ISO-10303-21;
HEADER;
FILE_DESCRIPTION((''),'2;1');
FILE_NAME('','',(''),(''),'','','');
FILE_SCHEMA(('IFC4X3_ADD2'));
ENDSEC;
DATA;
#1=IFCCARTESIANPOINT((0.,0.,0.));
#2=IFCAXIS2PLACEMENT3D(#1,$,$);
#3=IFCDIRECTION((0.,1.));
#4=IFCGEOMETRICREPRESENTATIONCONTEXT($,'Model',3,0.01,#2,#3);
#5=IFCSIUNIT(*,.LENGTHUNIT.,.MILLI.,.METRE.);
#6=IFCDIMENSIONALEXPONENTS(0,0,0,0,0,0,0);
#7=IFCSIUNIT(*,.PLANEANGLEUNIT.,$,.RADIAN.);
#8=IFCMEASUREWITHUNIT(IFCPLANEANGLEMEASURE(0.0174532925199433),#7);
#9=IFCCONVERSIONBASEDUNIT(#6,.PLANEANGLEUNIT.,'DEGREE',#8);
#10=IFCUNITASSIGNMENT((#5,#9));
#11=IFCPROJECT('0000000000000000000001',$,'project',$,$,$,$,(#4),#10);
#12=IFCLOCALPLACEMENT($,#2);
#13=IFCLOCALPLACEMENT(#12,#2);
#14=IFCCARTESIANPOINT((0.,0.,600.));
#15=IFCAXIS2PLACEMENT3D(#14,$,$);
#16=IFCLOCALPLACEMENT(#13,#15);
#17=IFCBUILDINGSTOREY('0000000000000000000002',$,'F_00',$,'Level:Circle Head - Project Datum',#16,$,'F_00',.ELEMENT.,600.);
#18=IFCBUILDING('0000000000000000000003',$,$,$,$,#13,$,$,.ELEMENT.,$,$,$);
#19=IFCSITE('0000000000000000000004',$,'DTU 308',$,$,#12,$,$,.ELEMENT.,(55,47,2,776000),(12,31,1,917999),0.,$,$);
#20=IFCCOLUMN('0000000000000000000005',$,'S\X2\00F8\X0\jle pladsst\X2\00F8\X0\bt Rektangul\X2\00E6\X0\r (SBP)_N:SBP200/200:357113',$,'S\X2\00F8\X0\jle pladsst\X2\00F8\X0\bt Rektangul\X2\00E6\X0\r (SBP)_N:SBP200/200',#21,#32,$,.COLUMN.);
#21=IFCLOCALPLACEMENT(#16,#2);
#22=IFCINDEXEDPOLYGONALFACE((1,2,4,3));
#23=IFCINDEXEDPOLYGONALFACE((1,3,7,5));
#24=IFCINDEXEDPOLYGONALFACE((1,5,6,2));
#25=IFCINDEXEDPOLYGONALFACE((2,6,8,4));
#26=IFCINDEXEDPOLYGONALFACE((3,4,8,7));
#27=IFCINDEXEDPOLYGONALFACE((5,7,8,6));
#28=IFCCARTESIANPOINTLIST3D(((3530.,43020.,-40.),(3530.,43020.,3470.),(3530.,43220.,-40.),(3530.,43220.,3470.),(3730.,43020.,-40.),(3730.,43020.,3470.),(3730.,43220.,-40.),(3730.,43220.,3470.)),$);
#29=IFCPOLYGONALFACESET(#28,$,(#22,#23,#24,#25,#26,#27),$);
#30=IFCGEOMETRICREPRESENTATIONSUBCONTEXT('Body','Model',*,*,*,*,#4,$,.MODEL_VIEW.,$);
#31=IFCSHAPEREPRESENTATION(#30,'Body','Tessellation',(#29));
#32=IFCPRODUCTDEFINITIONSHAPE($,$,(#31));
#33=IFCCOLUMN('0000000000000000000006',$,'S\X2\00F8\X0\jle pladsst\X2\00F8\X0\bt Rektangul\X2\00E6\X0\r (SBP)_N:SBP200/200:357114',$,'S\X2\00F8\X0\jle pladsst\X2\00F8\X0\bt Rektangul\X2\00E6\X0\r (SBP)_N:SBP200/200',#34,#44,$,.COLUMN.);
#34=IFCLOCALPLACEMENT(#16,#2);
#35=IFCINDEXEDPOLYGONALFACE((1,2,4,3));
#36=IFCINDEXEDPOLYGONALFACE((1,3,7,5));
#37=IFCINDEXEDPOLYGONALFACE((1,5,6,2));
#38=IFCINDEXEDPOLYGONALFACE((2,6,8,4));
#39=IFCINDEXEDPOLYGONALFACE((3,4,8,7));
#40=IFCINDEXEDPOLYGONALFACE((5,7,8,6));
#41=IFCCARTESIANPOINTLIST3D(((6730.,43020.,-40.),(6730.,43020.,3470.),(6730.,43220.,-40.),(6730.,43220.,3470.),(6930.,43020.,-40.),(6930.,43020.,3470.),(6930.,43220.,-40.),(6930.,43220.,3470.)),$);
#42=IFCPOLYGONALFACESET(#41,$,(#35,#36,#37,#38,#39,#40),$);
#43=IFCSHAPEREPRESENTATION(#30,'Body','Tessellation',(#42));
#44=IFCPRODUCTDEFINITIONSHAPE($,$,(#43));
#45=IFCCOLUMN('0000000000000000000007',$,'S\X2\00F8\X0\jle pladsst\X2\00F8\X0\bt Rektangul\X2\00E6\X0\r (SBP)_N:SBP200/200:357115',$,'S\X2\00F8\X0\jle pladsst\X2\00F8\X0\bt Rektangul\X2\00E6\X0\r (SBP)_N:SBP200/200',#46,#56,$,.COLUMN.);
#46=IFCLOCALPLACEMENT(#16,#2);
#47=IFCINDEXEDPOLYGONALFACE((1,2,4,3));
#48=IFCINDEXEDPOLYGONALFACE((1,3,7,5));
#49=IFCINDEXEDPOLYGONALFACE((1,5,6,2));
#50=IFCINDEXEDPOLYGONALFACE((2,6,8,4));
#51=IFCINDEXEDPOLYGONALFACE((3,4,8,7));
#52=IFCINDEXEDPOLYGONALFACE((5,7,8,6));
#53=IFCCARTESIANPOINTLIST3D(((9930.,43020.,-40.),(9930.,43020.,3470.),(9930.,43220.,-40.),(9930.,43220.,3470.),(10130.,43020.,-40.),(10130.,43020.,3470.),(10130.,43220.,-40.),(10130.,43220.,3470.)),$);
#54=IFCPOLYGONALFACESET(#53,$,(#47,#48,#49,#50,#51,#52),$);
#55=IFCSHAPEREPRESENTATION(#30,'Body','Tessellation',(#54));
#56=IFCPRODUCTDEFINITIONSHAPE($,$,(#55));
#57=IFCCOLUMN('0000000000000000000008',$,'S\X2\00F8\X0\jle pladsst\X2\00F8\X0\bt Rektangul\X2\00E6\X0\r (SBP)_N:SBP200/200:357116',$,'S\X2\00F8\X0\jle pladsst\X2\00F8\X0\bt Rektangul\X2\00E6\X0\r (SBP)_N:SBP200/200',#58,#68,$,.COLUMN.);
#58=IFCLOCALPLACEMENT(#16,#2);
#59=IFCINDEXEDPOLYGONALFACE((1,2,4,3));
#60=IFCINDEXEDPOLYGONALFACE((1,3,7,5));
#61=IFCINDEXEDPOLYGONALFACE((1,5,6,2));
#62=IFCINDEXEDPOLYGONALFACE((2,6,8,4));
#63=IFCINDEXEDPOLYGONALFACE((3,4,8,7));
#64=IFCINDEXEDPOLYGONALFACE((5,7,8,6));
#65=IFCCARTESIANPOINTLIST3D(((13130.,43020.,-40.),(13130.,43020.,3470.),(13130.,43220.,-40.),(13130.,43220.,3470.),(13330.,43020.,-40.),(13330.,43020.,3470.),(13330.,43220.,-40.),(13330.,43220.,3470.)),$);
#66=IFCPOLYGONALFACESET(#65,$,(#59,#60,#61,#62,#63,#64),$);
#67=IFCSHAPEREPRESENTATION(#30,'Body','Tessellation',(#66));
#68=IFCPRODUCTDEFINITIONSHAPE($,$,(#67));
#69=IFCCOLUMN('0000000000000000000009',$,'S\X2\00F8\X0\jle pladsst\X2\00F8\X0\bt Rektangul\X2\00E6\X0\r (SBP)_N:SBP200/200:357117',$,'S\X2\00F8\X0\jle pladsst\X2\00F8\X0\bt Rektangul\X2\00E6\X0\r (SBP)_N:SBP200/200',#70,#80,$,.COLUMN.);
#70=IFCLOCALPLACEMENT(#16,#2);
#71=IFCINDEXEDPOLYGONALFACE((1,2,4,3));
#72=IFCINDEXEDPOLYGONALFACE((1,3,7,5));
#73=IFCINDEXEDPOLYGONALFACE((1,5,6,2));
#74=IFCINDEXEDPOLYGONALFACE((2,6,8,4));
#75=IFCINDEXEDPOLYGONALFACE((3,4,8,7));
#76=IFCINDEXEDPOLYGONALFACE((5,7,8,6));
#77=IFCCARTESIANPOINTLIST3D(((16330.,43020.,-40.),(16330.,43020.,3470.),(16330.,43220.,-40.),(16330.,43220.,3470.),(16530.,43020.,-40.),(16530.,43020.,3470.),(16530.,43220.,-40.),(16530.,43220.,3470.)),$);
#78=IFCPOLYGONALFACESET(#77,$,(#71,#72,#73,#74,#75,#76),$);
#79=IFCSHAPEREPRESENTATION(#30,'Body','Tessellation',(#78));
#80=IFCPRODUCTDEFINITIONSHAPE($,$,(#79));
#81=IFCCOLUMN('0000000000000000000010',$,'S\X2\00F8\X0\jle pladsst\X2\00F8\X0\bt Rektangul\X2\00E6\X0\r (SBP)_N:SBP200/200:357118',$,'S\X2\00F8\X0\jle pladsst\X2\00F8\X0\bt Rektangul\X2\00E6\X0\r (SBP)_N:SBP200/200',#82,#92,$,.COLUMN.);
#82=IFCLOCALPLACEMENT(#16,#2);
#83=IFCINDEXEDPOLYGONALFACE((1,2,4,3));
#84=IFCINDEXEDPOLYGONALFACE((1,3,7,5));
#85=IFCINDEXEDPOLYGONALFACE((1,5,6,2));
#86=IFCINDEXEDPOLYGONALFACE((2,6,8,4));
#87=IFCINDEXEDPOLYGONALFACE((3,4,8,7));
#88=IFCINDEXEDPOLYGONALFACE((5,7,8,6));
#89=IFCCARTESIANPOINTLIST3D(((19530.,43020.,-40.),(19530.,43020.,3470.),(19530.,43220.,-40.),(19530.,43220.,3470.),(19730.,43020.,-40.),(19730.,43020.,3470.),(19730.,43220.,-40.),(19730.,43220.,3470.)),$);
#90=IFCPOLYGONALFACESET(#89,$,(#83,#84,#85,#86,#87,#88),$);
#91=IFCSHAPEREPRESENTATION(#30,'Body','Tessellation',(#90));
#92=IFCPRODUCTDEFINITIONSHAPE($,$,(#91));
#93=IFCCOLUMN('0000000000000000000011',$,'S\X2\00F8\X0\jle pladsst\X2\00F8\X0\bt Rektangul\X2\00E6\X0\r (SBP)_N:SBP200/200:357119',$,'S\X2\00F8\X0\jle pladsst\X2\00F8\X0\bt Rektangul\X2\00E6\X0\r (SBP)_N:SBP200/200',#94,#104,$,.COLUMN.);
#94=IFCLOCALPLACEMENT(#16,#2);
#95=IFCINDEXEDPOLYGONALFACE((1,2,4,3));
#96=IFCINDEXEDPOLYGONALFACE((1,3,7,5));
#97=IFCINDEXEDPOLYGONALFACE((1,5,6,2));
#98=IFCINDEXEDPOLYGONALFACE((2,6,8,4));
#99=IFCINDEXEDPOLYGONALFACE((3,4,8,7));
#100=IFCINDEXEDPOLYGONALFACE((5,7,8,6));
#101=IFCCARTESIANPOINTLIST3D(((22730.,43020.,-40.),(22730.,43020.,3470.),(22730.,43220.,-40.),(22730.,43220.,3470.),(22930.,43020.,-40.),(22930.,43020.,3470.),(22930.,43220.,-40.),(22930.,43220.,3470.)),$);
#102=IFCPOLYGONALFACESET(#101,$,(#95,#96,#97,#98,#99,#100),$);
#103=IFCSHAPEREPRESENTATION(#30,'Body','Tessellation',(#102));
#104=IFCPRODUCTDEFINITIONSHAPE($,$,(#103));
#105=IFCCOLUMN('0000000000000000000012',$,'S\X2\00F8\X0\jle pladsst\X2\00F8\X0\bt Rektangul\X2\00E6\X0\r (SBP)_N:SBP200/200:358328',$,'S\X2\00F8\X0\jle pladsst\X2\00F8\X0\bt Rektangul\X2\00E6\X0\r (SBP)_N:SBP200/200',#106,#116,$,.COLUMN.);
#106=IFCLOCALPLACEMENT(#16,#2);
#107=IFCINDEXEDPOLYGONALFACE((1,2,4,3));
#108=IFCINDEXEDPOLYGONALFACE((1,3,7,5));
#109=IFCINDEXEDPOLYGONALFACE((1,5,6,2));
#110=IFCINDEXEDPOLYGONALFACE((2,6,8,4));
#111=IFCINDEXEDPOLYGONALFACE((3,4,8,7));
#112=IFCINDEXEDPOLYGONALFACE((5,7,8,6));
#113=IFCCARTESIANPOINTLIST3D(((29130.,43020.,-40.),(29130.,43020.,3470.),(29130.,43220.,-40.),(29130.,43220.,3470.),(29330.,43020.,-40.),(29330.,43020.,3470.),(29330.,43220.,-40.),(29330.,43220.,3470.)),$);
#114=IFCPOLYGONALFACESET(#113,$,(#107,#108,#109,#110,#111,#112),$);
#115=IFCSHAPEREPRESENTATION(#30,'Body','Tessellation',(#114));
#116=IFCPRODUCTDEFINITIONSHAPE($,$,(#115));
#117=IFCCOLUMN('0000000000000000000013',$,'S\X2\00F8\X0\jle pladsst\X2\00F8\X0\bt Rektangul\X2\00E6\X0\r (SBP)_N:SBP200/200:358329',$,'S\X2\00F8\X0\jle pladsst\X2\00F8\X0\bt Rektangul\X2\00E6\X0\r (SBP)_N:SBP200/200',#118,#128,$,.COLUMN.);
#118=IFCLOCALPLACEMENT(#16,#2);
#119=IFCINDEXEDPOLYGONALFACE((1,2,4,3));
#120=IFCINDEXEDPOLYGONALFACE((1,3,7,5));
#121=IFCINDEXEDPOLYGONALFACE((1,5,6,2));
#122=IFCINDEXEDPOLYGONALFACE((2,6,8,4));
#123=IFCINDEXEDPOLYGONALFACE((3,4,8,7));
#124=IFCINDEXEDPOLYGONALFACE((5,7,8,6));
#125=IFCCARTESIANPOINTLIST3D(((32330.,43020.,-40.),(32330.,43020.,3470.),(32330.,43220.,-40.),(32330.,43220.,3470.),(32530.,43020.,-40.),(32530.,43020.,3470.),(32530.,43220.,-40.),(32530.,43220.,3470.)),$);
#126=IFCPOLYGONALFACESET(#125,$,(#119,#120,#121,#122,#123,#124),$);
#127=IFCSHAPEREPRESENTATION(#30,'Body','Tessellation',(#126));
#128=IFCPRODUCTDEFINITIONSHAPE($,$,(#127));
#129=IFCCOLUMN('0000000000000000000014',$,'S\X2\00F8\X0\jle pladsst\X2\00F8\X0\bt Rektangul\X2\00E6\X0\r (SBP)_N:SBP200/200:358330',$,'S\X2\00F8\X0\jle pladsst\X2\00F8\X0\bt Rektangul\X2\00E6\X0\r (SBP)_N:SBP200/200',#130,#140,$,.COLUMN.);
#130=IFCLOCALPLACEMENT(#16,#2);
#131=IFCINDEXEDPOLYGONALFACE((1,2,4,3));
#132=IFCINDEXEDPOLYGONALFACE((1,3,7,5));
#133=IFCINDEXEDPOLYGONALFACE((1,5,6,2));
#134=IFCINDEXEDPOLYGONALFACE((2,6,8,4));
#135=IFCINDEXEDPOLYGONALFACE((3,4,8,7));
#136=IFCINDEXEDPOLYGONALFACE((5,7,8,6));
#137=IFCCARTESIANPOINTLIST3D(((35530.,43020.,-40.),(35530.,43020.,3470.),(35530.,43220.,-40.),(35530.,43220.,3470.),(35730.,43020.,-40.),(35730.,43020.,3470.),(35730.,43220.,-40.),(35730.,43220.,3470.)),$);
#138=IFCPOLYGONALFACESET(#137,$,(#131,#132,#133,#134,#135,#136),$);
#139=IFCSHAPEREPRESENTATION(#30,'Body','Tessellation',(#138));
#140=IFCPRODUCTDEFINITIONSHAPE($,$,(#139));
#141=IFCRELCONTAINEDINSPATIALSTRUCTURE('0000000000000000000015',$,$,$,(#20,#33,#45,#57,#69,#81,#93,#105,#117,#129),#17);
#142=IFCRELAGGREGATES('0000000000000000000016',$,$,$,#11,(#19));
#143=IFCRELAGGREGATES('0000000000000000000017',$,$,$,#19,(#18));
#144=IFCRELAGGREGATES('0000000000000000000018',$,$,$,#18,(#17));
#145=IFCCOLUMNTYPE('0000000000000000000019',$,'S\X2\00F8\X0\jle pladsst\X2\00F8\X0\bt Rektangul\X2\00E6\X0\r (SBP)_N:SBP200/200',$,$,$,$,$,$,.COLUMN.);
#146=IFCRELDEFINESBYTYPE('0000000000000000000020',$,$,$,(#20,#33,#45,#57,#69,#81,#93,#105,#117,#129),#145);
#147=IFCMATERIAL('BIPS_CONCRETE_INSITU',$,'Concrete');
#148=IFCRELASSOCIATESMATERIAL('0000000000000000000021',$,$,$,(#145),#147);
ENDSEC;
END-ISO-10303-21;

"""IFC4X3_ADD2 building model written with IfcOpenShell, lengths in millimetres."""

from ifc_helpers import new_model, entity, si_unit, converted_unit, direction, frame, frame_2d, origin, place, context, subcontext, project, spatial, rectangle, extrude, source, transform, mapped, material, material_profile, profile_set, type_object, element, save


model = new_model("IFC4X3_ADD2")

# Units and contexts
model_context = context("Model", 3, precision=0.01, world=origin(), true_north=direction((0.0, 1.0)))
body_context = subcontext(model_context, "Body", "Model", "MODEL_VIEW")
ifc_project = project(units=[si_unit("LENGTHUNIT", "METRE", prefix="MILLI"), converted_unit("PLANEANGLEUNIT", "DEGREE", entity("IfcPlaneAngleMeasure", 0.0174532925199433), si_unit("PLANEANGLEUNIT", "RADIAN"), dimensions=[0, 0, 0, 0, 0, 0, 0])], contexts=[model_context])

# Site, building, storey
site_placement = place(None, origin())
site = spatial("IfcSite", under=ifc_project, at=site_placement, Name="DTU 308", CompositionType="ELEMENT", RefLatitude=(55, 47, 2, 776000), RefLongitude=(12, 31, 1, 917999), RefElevation=0.0)
building_placement = place(site_placement, origin())
building = spatial("IfcBuilding", under=site, at=building_placement, CompositionType="ELEMENT")
storey_placement = place(building_placement, frame((0.0, 0.0, 600.0)))
storey = spatial("IfcBuildingStorey", under=building, at=storey_placement, Name="F_00", ObjectType="Level:Circle Head - Project Datum", LongName="F_00", CompositionType="ELEMENT", Elevation=600.0)

# Columns
ifc_material_1 = material(Name="BIPS_CONCRETE_INSITU", Category="Concrete")
ifc_material_profile_1 = material_profile(ifc_material_1, rectangle(XDim=200.0, YDim=200.0, at=frame_2d((0.0, 0.0), x_axis=(1.0, 0.0))), Name="SBP200/200")
ifc_profile_set_1 = profile_set([ifc_material_profile_1], Name="SBP200/200")
column_type_1 = type_object("IfcColumnType", Name="Søjle pladsstøbt Rektangulær (SBP)_N:SBP200/200", PredefinedType="COLUMN", material=ifc_profile_set_1)
shared_shape_1 = source(origin(), body_context, "Body", "SweptSolid", [
    extrude(rectangle(XDim=200.0, YDim=200.0, at=frame_2d((0.0, 0.0), x_axis=(1.0, 0.0))), frame((3630.0, 43120.0, 560.0), z_axis=(0.0, 0.0, 1.0), x_axis=(0.0, 1.0, 0.0)), (0.0, 0.0, 1.0), 3510.0),
])
column_1_placement = place(storey_placement, frame((0.0, 0.0, -600.0)))
element("IfcColumn", 1, at=column_1_placement, inside=storey, type_object=column_type_1, Name="Søjle pladsstøbt Rektangulær (SBP)_N:SBP200/200:357113", ObjectType="Søjle pladsstøbt Rektangulær (SBP)_N:SBP200/200", PredefinedType="COLUMN", context=body_context, shape_type="MappedRepresentation", body=[
    mapped(shared_shape_1, transform((0.0, 0.0, 0.0), scale=1.0)),
])
shared_shape_2 = source(origin(), body_context, "Body", "SweptSolid", [
    extrude(rectangle(XDim=200.0, YDim=200.0, at=frame_2d((0.0, 0.0), x_axis=(1.0, 0.0))), frame((6830.0, 43120.0, 560.0), z_axis=(0.0, 0.0, 1.0), x_axis=(0.0, 1.0, 0.0)), (0.0, 0.0, 1.0), 3510.0),
])
column_2_placement = place(storey_placement, frame((0.0, 0.0, -600.0)))
element("IfcColumn", 2, at=column_2_placement, inside=storey, type_object=column_type_1, Name="Søjle pladsstøbt Rektangulær (SBP)_N:SBP200/200:357114", ObjectType="Søjle pladsstøbt Rektangulær (SBP)_N:SBP200/200", PredefinedType="COLUMN", context=body_context, shape_type="MappedRepresentation", body=[
    mapped(shared_shape_2, transform((0.0, 0.0, 0.0), scale=1.0)),
])
shared_shape_3 = source(origin(), body_context, "Body", "SweptSolid", [
    extrude(rectangle(XDim=200.0, YDim=200.0, at=frame_2d((0.0, 0.0), x_axis=(1.0, 0.0))), frame((10030.0, 43120.0, 560.0), z_axis=(0.0, 0.0, 1.0), x_axis=(0.0, 1.0, 0.0)), (0.0, 0.0, 1.0), 3510.0),
])
column_3_placement = place(storey_placement, frame((0.0, 0.0, -600.0)))
element("IfcColumn", 3, at=column_3_placement, inside=storey, type_object=column_type_1, Name="Søjle pladsstøbt Rektangulær (SBP)_N:SBP200/200:357115", ObjectType="Søjle pladsstøbt Rektangulær (SBP)_N:SBP200/200", PredefinedType="COLUMN", context=body_context, shape_type="MappedRepresentation", body=[
    mapped(shared_shape_3, transform((0.0, 0.0, 0.0), scale=1.0)),
])
shared_shape_4 = source(origin(), body_context, "Body", "SweptSolid", [
    extrude(rectangle(XDim=200.0, YDim=200.0, at=frame_2d((0.0, 0.0), x_axis=(1.0, 0.0))), frame((13230.0, 43120.0, 560.0), z_axis=(0.0, 0.0, 1.0), x_axis=(0.0, 1.0, 0.0)), (0.0, 0.0, 1.0), 3510.0),
])
column_4_placement = place(storey_placement, frame((0.0, 0.0, -600.0)))
element("IfcColumn", 4, at=column_4_placement, inside=storey, type_object=column_type_1, Name="Søjle pladsstøbt Rektangulær (SBP)_N:SBP200/200:357116", ObjectType="Søjle pladsstøbt Rektangulær (SBP)_N:SBP200/200", PredefinedType="COLUMN", context=body_context, shape_type="MappedRepresentation", body=[
    mapped(shared_shape_4, transform((0.0, 0.0, 0.0), scale=1.0)),
])
shared_shape_5 = source(origin(), body_context, "Body", "SweptSolid", [
    extrude(rectangle(XDim=200.0, YDim=200.0, at=frame_2d((0.0, 0.0), x_axis=(1.0, 0.0))), frame((16430.0, 43120.0, 560.0), z_axis=(0.0, 0.0, 1.0), x_axis=(0.0, 1.0, 0.0)), (0.0, 0.0, 1.0), 3510.0),
])
column_5_placement = place(storey_placement, frame((0.0, 0.0, -600.0)))
element("IfcColumn", 5, at=column_5_placement, inside=storey, type_object=column_type_1, Name="Søjle pladsstøbt Rektangulær (SBP)_N:SBP200/200:357117", ObjectType="Søjle pladsstøbt Rektangulær (SBP)_N:SBP200/200", PredefinedType="COLUMN", context=body_context, shape_type="MappedRepresentation", body=[
    mapped(shared_shape_5, transform((0.0, 0.0, 0.0), scale=1.0)),
])
shared_shape_6 = source(origin(), body_context, "Body", "SweptSolid", [
    extrude(rectangle(XDim=200.0, YDim=200.0, at=frame_2d((0.0, 0.0), x_axis=(1.0, 0.0))), frame((19630.0, 43120.0, 560.0), z_axis=(0.0, 0.0, 1.0), x_axis=(0.0, 1.0, 0.0)), (0.0, 0.0, 1.0), 3510.0),
])
column_6_placement = place(storey_placement, frame((0.0, 0.0, -600.0)))
element("IfcColumn", 6, at=column_6_placement, inside=storey, type_object=column_type_1, Name="Søjle pladsstøbt Rektangulær (SBP)_N:SBP200/200:357118", ObjectType="Søjle pladsstøbt Rektangulær (SBP)_N:SBP200/200", PredefinedType="COLUMN", context=body_context, shape_type="MappedRepresentation", body=[
    mapped(shared_shape_6, transform((0.0, 0.0, 0.0), scale=1.0)),
])
shared_shape_7 = source(origin(), body_context, "Body", "SweptSolid", [
    extrude(rectangle(XDim=200.0, YDim=200.0, at=frame_2d((0.0, 0.0), x_axis=(1.0, 0.0))), frame((22830.0, 43120.0, 560.0), z_axis=(0.0, 0.0, 1.0), x_axis=(0.0, 1.0, 0.0)), (0.0, 0.0, 1.0), 3510.0),
])
column_7_placement = place(storey_placement, frame((0.0, 0.0, -600.0)))
element("IfcColumn", 7, at=column_7_placement, inside=storey, type_object=column_type_1, Name="Søjle pladsstøbt Rektangulær (SBP)_N:SBP200/200:357119", ObjectType="Søjle pladsstøbt Rektangulær (SBP)_N:SBP200/200", PredefinedType="COLUMN", context=body_context, shape_type="MappedRepresentation", body=[
    mapped(shared_shape_7, transform((0.0, 0.0, 0.0), scale=1.0)),
])
shared_shape_8 = source(origin(), body_context, "Body", "SweptSolid", [
    extrude(rectangle(XDim=200.0, YDim=200.0, at=frame_2d((0.0, 0.0), x_axis=(1.0, 0.0))), frame((29230.0, 43120.0, 560.0), z_axis=(0.0, 0.0, 1.0), x_axis=(0.0, 1.0, 0.0)), (0.0, 0.0, 1.0), 3510.0),
])
column_8_placement = place(storey_placement, frame((0.0, 0.0, -600.0)))
element("IfcColumn", 8, at=column_8_placement, inside=storey, type_object=column_type_1, Name="Søjle pladsstøbt Rektangulær (SBP)_N:SBP200/200:358328", ObjectType="Søjle pladsstøbt Rektangulær (SBP)_N:SBP200/200", PredefinedType="COLUMN", context=body_context, shape_type="MappedRepresentation", body=[
    mapped(shared_shape_8, transform((0.0, 0.0, 0.0), scale=1.0)),
])
shared_shape_9 = source(origin(), body_context, "Body", "SweptSolid", [
    extrude(rectangle(XDim=200.0, YDim=200.0, at=frame_2d((0.0, 0.0), x_axis=(1.0, 0.0))), frame((32430.0, 43120.0, 560.0), z_axis=(0.0, 0.0, 1.0), x_axis=(0.0, 1.0, 0.0)), (0.0, 0.0, 1.0), 3510.0),
])
column_9_placement = place(storey_placement, frame((0.0, 0.0, -600.0)))
element("IfcColumn", 9, at=column_9_placement, inside=storey, type_object=column_type_1, Name="Søjle pladsstøbt Rektangulær (SBP)_N:SBP200/200:358329", ObjectType="Søjle pladsstøbt Rektangulær (SBP)_N:SBP200/200", PredefinedType="COLUMN", context=body_context, shape_type="MappedRepresentation", body=[
    mapped(shared_shape_9, transform((0.0, 0.0, 0.0), scale=1.0)),
])
shared_shape_10 = source(origin(), body_context, "Body", "SweptSolid", [
    extrude(rectangle(XDim=200.0, YDim=200.0, at=frame_2d((0.0, 0.0), x_axis=(1.0, 0.0))), frame((35630.0, 43120.0, 560.0), z_axis=(0.0, 0.0, 1.0), x_axis=(0.0, 1.0, 0.0)), (0.0, 0.0, 1.0), 3510.0),
])
column_10_placement = place(storey_placement, frame((0.0, 0.0, -600.0)))
element("IfcColumn", 10, at=column_10_placement, inside=storey, type_object=column_type_1, Name="Søjle pladsstøbt Rektangulær (SBP)_N:SBP200/200:358330", ObjectType="Søjle pladsstøbt Rektangulær (SBP)_N:SBP200/200", PredefinedType="COLUMN", context=body_context, shape_type="MappedRepresentation", body=[
    mapped(shared_shape_10, transform((0.0, 0.0, 0.0), scale=1.0)),
])

save(model, "model.ifc")
